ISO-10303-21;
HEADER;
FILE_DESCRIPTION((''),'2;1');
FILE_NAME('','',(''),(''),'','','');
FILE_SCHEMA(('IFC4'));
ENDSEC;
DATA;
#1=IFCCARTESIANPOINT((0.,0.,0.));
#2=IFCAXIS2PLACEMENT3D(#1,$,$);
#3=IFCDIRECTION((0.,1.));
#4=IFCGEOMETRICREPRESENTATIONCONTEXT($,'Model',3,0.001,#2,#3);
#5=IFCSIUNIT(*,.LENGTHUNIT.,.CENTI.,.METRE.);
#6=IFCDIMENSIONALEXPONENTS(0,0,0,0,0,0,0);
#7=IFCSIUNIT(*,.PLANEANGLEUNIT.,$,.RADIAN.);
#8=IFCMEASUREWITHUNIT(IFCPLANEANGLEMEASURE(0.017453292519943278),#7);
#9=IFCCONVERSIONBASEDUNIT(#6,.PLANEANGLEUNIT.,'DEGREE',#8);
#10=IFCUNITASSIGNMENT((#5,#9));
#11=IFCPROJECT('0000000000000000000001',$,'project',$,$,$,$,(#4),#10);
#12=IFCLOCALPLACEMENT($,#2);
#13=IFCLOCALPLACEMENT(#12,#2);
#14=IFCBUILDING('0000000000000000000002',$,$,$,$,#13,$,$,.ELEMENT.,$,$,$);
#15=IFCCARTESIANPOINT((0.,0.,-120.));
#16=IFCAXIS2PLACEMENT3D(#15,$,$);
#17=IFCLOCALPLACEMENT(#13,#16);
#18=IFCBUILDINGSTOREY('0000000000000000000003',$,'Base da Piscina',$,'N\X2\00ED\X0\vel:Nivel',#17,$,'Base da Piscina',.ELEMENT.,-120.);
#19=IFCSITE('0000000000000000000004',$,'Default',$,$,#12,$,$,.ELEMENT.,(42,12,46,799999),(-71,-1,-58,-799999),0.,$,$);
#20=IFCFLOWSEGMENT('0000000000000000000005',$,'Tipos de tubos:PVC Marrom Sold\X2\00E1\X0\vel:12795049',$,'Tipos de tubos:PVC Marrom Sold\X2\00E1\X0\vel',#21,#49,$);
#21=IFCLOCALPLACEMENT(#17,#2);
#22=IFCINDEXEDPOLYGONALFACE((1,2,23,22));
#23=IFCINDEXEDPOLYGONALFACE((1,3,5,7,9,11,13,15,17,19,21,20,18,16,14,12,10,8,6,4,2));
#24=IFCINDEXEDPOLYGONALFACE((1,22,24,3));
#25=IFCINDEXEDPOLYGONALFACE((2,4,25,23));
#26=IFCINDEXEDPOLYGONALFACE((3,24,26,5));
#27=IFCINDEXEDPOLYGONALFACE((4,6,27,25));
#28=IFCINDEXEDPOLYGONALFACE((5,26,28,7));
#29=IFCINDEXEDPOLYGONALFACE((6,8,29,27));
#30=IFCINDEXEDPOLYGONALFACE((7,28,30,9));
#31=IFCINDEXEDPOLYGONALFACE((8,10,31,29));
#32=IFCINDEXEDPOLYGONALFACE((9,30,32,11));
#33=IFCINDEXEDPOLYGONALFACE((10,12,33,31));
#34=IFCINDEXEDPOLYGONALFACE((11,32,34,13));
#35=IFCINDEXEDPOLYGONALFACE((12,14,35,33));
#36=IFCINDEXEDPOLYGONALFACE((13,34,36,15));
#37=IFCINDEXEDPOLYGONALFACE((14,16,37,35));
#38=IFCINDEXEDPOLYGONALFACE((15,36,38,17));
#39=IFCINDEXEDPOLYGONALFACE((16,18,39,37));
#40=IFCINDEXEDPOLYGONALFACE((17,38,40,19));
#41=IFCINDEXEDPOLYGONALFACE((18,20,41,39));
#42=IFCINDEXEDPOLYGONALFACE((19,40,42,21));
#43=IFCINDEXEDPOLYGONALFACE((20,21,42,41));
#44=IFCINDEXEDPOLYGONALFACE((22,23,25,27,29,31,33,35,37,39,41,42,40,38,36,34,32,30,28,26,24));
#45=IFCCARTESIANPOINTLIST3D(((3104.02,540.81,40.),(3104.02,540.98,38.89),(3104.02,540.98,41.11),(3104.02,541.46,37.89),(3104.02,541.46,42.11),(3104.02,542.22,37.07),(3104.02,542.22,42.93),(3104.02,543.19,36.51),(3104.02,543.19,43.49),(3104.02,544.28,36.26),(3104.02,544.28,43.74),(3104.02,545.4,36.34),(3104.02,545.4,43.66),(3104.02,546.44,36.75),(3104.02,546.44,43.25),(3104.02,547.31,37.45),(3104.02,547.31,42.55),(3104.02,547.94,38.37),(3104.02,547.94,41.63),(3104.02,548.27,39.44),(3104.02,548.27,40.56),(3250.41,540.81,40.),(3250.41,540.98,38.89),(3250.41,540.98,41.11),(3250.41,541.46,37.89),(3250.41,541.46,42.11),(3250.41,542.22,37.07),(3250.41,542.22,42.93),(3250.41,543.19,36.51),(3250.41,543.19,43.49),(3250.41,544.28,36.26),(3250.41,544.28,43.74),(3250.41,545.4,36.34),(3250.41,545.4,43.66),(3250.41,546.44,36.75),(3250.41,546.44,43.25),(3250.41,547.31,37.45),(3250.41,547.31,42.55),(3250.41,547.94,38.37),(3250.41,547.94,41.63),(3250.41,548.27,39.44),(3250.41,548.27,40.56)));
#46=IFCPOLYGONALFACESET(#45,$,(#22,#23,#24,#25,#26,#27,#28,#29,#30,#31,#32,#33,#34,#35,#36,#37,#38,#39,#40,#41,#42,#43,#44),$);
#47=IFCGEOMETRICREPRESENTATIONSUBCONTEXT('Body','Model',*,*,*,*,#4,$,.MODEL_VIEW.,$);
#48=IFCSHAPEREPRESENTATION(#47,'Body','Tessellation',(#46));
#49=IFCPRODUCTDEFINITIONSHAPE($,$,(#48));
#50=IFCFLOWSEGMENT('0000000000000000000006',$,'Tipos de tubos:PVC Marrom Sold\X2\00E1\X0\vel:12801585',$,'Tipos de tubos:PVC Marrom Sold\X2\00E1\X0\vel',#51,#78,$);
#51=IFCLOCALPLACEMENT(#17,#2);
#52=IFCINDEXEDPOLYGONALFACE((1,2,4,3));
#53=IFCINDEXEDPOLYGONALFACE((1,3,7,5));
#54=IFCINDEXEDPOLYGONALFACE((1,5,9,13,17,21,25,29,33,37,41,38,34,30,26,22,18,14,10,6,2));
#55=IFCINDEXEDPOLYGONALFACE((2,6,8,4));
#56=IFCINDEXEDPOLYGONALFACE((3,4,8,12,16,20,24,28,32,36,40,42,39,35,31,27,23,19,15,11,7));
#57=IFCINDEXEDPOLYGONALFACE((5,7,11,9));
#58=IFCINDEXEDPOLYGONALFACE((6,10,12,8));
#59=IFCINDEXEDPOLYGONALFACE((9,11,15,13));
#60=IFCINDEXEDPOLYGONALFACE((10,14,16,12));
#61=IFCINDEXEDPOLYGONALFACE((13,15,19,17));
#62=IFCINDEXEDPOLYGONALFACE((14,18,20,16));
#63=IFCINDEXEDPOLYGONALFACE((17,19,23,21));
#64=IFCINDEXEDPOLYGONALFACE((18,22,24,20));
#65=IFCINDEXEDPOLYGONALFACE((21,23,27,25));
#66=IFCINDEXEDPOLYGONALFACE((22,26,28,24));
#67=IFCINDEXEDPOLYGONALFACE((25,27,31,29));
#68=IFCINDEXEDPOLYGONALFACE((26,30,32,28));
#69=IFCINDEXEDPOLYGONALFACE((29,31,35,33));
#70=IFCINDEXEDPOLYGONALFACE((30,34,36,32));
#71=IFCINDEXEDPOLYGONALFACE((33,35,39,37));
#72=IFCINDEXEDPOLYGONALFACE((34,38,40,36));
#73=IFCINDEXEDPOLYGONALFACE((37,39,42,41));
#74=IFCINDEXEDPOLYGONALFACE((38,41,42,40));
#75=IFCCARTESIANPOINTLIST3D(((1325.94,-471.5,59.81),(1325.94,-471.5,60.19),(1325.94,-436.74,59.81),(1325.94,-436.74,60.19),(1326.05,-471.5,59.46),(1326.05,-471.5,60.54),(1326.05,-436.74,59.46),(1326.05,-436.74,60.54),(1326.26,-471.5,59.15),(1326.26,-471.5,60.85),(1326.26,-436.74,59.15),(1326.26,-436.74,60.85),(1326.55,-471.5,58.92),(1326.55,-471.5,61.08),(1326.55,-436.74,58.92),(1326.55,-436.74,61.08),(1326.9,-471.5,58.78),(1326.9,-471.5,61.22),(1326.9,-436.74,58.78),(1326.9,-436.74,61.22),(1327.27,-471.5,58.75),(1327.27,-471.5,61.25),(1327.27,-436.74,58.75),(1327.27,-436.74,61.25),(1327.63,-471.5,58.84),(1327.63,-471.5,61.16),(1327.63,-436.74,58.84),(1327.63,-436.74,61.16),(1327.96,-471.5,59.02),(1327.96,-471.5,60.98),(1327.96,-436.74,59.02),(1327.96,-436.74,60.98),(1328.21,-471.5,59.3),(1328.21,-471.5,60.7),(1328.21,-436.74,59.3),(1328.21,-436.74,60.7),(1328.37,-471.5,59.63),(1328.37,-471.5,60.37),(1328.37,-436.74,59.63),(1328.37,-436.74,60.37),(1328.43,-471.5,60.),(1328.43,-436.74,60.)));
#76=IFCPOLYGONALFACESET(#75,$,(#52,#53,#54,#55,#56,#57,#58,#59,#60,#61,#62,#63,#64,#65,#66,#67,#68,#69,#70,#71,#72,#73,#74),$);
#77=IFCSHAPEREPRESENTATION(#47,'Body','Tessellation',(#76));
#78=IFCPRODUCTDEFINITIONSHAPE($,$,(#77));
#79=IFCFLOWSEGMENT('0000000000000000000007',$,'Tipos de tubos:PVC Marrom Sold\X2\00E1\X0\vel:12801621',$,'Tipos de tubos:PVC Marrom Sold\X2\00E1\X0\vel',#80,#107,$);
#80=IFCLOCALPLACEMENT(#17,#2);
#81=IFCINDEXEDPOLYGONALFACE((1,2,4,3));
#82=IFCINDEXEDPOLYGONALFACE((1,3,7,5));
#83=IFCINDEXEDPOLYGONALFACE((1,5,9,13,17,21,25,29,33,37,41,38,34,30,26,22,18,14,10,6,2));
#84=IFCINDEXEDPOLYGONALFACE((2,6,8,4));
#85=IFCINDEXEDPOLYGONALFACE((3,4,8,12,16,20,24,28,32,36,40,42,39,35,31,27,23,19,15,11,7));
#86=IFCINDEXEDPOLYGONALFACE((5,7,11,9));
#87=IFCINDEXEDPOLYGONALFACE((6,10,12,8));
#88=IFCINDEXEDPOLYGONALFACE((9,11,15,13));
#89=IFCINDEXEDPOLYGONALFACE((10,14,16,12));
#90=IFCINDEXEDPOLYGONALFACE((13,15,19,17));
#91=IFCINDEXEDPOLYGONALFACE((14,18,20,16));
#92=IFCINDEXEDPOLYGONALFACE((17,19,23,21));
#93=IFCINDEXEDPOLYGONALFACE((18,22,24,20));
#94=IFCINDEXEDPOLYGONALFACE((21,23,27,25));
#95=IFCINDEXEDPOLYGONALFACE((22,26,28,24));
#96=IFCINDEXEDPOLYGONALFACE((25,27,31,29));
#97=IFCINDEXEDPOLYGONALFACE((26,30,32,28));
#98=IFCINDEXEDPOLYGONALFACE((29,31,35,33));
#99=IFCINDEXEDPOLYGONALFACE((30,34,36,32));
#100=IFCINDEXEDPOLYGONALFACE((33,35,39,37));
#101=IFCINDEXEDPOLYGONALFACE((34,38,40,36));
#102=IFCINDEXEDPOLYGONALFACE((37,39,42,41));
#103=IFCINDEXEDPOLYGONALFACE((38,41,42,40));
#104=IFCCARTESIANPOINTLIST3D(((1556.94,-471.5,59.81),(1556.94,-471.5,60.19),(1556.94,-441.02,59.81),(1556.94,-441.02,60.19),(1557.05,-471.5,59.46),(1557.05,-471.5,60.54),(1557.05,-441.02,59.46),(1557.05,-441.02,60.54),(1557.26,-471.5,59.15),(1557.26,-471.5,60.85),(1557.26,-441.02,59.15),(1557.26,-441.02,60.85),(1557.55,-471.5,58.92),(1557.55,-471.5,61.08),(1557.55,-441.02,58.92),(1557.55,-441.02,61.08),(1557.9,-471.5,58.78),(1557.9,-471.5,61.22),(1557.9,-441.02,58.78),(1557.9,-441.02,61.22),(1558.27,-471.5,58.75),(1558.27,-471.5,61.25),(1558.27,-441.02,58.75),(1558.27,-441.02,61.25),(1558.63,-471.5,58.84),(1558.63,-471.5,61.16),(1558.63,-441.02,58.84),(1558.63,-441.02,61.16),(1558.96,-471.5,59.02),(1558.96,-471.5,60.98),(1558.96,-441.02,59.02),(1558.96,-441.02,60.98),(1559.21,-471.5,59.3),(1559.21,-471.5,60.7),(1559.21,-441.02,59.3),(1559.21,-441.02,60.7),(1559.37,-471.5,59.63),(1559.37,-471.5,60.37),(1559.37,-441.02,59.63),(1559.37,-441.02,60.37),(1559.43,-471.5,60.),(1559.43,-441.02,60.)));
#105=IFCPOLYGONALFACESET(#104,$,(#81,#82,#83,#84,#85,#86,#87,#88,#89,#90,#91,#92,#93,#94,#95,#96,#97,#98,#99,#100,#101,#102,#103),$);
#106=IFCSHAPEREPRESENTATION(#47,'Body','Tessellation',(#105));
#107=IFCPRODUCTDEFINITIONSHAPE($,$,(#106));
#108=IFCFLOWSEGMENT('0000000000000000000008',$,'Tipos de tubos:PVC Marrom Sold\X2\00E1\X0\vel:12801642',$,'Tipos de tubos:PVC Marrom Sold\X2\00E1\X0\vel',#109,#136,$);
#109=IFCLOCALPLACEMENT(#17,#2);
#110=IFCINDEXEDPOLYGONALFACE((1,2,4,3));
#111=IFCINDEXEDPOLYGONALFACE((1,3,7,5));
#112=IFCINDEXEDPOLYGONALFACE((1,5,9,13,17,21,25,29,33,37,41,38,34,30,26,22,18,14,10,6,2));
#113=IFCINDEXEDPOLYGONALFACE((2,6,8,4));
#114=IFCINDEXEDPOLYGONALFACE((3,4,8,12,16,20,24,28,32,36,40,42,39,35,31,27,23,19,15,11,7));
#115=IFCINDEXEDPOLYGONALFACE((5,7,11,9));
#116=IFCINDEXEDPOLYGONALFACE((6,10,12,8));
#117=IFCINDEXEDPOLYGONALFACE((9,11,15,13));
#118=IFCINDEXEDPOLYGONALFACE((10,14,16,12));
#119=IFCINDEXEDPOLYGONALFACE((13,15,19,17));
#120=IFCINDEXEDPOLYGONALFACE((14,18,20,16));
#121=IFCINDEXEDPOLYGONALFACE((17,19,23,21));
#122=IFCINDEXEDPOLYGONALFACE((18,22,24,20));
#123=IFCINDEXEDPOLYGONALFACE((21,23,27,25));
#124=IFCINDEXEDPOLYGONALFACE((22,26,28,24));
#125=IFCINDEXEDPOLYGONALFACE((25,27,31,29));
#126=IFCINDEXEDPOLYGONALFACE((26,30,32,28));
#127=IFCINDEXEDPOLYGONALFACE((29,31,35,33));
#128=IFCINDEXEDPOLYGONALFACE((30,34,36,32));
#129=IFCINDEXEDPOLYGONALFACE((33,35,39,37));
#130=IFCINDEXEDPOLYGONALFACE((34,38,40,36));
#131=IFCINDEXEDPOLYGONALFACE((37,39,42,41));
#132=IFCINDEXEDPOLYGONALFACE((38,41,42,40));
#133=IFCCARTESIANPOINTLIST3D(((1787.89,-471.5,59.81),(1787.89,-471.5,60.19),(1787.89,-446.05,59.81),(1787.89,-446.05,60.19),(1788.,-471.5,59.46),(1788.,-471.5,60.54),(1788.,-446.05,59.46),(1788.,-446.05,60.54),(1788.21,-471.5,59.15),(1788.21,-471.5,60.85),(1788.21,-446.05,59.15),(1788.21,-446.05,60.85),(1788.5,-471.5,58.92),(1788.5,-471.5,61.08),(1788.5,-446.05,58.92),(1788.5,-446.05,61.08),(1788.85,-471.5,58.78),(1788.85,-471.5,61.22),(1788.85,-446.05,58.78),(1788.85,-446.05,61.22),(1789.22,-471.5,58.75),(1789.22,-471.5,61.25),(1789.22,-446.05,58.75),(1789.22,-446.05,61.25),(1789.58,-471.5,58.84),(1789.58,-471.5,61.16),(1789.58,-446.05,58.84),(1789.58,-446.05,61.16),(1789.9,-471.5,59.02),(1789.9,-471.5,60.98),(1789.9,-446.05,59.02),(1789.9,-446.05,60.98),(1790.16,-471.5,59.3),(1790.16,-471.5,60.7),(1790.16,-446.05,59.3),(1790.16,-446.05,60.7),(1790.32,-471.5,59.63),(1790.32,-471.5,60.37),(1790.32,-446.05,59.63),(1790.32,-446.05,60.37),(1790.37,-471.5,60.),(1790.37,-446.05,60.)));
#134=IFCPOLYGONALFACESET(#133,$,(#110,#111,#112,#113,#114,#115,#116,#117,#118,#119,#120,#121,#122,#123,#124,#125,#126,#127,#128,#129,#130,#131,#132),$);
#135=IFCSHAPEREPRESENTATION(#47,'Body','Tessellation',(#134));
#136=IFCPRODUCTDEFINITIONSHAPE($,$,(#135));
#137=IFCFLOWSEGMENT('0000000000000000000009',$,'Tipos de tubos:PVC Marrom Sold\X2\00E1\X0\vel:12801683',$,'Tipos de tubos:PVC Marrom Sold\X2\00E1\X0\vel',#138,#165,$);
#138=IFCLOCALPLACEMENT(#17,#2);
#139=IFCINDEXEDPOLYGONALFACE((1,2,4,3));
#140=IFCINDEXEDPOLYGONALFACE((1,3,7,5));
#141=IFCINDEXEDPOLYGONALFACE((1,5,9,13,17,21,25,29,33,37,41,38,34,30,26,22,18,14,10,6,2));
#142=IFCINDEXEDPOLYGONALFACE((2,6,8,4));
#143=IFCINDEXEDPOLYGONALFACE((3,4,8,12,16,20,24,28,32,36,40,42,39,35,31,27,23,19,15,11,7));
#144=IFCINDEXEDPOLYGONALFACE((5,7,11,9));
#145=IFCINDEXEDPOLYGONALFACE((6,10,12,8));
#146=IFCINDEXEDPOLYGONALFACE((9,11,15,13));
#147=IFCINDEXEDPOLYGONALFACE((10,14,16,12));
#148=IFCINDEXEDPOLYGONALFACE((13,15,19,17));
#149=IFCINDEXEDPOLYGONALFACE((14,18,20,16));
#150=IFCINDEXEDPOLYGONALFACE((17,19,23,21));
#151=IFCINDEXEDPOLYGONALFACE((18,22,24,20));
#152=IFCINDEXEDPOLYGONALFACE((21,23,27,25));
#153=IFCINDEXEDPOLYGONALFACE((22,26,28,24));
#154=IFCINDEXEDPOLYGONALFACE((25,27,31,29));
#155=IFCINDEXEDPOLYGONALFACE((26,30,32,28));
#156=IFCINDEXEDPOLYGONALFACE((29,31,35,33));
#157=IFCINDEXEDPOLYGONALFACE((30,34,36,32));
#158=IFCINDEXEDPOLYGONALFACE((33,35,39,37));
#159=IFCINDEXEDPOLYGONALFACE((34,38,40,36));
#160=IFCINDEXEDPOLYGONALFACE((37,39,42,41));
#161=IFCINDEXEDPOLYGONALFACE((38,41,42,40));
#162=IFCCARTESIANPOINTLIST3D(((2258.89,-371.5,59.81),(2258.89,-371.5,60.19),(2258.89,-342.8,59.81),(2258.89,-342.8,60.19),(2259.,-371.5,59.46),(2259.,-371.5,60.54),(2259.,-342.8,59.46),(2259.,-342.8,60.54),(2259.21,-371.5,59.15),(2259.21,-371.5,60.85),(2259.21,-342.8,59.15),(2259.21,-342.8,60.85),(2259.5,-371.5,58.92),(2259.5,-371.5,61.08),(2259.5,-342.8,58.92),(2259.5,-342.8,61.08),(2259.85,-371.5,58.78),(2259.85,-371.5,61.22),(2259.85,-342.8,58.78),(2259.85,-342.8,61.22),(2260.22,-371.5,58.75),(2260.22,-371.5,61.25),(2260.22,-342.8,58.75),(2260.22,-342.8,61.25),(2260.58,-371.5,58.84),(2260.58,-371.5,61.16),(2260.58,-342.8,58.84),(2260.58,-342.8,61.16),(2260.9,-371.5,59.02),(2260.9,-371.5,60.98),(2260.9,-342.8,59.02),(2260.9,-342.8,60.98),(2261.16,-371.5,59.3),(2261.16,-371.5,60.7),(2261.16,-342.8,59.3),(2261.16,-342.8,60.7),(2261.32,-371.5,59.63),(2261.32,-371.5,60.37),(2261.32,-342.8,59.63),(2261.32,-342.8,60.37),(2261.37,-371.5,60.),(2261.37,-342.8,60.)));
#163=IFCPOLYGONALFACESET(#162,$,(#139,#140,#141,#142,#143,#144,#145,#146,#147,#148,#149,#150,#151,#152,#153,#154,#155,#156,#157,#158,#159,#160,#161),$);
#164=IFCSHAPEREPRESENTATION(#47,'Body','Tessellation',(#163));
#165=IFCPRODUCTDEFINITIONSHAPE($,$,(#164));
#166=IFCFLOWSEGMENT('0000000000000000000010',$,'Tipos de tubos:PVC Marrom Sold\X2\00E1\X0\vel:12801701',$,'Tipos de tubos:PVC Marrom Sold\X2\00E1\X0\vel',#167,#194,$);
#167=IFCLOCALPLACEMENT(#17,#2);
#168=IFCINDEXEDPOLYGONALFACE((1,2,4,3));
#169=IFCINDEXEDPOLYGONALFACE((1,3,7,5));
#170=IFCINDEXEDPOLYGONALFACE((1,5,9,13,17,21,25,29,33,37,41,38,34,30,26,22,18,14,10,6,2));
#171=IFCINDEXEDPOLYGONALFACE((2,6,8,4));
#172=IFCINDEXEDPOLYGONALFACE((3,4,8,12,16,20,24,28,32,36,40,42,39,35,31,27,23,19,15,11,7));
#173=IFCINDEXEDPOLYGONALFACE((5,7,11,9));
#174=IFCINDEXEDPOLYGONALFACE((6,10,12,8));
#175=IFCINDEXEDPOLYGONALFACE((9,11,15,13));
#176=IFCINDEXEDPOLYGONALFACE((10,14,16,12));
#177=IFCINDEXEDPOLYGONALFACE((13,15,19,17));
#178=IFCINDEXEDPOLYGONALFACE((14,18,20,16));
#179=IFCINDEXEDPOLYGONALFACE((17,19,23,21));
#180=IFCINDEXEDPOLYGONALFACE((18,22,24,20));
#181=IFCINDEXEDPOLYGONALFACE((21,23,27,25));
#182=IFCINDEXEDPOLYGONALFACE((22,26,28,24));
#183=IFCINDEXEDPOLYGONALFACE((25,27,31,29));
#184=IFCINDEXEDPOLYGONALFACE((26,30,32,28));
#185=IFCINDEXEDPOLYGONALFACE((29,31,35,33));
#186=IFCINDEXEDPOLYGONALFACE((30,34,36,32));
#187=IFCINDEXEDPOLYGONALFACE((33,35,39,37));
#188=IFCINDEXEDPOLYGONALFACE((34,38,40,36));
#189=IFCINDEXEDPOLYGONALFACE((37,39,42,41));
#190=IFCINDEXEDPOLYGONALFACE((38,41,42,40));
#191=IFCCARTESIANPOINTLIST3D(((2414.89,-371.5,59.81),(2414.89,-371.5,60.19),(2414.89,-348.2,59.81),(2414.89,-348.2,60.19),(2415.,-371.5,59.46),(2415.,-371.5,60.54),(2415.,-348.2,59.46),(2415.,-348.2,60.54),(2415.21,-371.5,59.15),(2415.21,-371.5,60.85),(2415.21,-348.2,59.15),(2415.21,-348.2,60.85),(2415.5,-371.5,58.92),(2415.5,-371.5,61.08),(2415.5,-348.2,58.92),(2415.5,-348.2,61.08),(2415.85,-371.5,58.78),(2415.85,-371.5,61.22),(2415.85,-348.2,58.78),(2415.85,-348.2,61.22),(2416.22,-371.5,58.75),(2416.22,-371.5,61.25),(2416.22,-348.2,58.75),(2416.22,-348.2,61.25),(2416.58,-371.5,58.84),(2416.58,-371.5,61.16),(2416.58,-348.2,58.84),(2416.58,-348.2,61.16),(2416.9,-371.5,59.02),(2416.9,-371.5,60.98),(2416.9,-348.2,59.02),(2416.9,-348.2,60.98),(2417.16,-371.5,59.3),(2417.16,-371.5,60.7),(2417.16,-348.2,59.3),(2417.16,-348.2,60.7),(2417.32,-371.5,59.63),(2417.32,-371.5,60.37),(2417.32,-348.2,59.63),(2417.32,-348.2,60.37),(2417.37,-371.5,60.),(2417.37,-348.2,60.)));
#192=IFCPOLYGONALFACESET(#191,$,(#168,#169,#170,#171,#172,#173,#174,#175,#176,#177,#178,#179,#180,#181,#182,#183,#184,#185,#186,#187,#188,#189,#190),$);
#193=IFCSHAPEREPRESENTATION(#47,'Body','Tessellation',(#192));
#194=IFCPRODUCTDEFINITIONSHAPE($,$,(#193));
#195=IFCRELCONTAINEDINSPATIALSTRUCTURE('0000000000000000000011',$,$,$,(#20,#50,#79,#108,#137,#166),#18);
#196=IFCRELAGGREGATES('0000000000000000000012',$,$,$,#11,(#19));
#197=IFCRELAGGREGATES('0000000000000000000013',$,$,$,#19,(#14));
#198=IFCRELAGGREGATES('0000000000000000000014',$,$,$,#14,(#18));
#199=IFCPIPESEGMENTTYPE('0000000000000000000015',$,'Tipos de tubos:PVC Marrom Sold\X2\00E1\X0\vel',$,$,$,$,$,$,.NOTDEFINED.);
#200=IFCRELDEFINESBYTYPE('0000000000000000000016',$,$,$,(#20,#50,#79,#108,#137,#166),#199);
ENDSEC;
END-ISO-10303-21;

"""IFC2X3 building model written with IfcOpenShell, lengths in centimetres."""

from ifc_helpers import new_model, entity, si_unit, converted_unit, direction, frame, origin, origin_2d_with_axis, place, context, subcontext, project, spatial, circle, extrude, type_object, element, save


model = new_model("IFC2X3")

# Units and contexts
model_context = context("Model", 3, precision=0.001, world=origin(), true_north=direction((0.0, 1.0)))
body_context = subcontext(model_context, "Body", "Model", "MODEL_VIEW")
ifc_project = project(units=[si_unit("LENGTHUNIT", "METRE", prefix="CENTI"), converted_unit("PLANEANGLEUNIT", "DEGREE", entity("IfcPlaneAngleMeasure", 0.017453292519943278), si_unit("PLANEANGLEUNIT", "RADIAN"), dimensions=[0, 0, 0, 0, 0, 0, 0])], contexts=[model_context])

# Site, building, storey
site_placement = place(None, origin())
site = spatial("IfcSite", under=ifc_project, at=site_placement, Name="Default", CompositionType="ELEMENT", RefLatitude=(42, 12, 46, 799999), RefLongitude=(-71, -1, -58, -799999), RefElevation=0.0)
building_placement = place(site_placement, origin())
building = spatial("IfcBuilding", under=site, at=building_placement, CompositionType="ELEMENT")
storey_placement = place(building_placement, frame((0.0, 0.0, -120.0)))
storey = spatial("IfcBuildingStorey", under=building, at=storey_placement, Name="Base da Piscina", ObjectType="Nível:Nivel", LongName="Base da Piscina", CompositionType="ELEMENT", Elevation=-120.0)

# Flow segments
pipe_segment_type = type_object("IfcPipeSegmentType", Name="Tipos de tubos:PVC Marrom Soldável", PredefinedType="NOTDEFINED")
flow_segment_1_placement = place(storey_placement, origin())
element("IfcFlowSegment", 1, at=flow_segment_1_placement, inside=storey, type_object=pipe_segment_type, Name="Tipos de tubos:PVC Marrom Soldável:12795049", ObjectType="Tipos de tubos:PVC Marrom Soldável", context=body_context, shape_type="SweptSolid", body=[
    extrude(circle(Radius=3.75, at=origin_2d_with_axis()), frame((3104.02, 544.56, 40.0), z_axis=(1.0, 0.0, 0.0), x_axis=(0.0, -1.0, 0.0)), (0.0, 0.0, 1.0), 146.39),
])
flow_segment_2_placement = place(storey_placement, origin())
element("IfcFlowSegment", 2, at=flow_segment_2_placement, inside=storey, type_object=pipe_segment_type, Name="Tipos de tubos:PVC Marrom Soldável:12801585", ObjectType="Tipos de tubos:PVC Marrom Soldável", context=body_context, shape_type="SweptSolid", body=[
    extrude(circle(Radius=1.25, at=origin_2d_with_axis()), frame((1327.18, -471.5, 60.0), z_axis=(0.0, 1.0, 0.0), x_axis=(1.0, 0.0, 0.0)), (0.0, 0.0, 1.0), 34.76),
])
flow_segment_3_placement = place(storey_placement, origin())
element("IfcFlowSegment", 3, at=flow_segment_3_placement, inside=storey, type_object=pipe_segment_type, Name="Tipos de tubos:PVC Marrom Soldável:12801621", ObjectType="Tipos de tubos:PVC Marrom Soldável", context=body_context, shape_type="SweptSolid", body=[
    extrude(circle(Radius=1.25, at=origin_2d_with_axis()), frame((1558.18, -471.5, 60.0), z_axis=(0.0, 1.0, 0.0), x_axis=(1.0, 0.0, 0.0)), (0.0, 0.0, 1.0), 30.48),
])
flow_segment_4_placement = place(storey_placement, origin())
element("IfcFlowSegment", 4, at=flow_segment_4_placement, inside=storey, type_object=pipe_segment_type, Name="Tipos de tubos:PVC Marrom Soldável:12801642", ObjectType="Tipos de tubos:PVC Marrom Soldável", context=body_context, shape_type="SweptSolid", body=[
    extrude(circle(Radius=1.25, at=origin_2d_with_axis()), frame((1789.12, -471.5, 60.0), z_axis=(0.0, 1.0, 0.0), x_axis=(1.0, 0.0, 0.0)), (0.0, 0.0, 1.0), 25.45),
])
flow_segment_5_placement = place(storey_placement, origin())
element("IfcFlowSegment", 5, at=flow_segment_5_placement, inside=storey, type_object=pipe_segment_type, Name="Tipos de tubos:PVC Marrom Soldável:12801683", ObjectType="Tipos de tubos:PVC Marrom Soldável", context=body_context, shape_type="SweptSolid", body=[
    extrude(circle(Radius=1.25, at=origin_2d_with_axis()), frame((2260.12, -371.5, 60.0), z_axis=(0.0, 1.0, 0.0), x_axis=(1.0, 0.0, 0.0)), (0.0, 0.0, 1.0), 28.7),
])
flow_segment_6_placement = place(storey_placement, origin())
element("IfcFlowSegment", 6, at=flow_segment_6_placement, inside=storey, type_object=pipe_segment_type, Name="Tipos de tubos:PVC Marrom Soldável:12801701", ObjectType="Tipos de tubos:PVC Marrom Soldável", context=body_context, shape_type="SweptSolid", body=[
    extrude(circle(Radius=1.25, at=origin_2d_with_axis()), frame((2416.12, -371.5, 60.0), z_axis=(0.0, 1.0, 0.0), x_axis=(1.0, 0.0, 0.0)), (0.0, 0.0, 1.0), 23.3),
])

save(model, "model.ifc")
